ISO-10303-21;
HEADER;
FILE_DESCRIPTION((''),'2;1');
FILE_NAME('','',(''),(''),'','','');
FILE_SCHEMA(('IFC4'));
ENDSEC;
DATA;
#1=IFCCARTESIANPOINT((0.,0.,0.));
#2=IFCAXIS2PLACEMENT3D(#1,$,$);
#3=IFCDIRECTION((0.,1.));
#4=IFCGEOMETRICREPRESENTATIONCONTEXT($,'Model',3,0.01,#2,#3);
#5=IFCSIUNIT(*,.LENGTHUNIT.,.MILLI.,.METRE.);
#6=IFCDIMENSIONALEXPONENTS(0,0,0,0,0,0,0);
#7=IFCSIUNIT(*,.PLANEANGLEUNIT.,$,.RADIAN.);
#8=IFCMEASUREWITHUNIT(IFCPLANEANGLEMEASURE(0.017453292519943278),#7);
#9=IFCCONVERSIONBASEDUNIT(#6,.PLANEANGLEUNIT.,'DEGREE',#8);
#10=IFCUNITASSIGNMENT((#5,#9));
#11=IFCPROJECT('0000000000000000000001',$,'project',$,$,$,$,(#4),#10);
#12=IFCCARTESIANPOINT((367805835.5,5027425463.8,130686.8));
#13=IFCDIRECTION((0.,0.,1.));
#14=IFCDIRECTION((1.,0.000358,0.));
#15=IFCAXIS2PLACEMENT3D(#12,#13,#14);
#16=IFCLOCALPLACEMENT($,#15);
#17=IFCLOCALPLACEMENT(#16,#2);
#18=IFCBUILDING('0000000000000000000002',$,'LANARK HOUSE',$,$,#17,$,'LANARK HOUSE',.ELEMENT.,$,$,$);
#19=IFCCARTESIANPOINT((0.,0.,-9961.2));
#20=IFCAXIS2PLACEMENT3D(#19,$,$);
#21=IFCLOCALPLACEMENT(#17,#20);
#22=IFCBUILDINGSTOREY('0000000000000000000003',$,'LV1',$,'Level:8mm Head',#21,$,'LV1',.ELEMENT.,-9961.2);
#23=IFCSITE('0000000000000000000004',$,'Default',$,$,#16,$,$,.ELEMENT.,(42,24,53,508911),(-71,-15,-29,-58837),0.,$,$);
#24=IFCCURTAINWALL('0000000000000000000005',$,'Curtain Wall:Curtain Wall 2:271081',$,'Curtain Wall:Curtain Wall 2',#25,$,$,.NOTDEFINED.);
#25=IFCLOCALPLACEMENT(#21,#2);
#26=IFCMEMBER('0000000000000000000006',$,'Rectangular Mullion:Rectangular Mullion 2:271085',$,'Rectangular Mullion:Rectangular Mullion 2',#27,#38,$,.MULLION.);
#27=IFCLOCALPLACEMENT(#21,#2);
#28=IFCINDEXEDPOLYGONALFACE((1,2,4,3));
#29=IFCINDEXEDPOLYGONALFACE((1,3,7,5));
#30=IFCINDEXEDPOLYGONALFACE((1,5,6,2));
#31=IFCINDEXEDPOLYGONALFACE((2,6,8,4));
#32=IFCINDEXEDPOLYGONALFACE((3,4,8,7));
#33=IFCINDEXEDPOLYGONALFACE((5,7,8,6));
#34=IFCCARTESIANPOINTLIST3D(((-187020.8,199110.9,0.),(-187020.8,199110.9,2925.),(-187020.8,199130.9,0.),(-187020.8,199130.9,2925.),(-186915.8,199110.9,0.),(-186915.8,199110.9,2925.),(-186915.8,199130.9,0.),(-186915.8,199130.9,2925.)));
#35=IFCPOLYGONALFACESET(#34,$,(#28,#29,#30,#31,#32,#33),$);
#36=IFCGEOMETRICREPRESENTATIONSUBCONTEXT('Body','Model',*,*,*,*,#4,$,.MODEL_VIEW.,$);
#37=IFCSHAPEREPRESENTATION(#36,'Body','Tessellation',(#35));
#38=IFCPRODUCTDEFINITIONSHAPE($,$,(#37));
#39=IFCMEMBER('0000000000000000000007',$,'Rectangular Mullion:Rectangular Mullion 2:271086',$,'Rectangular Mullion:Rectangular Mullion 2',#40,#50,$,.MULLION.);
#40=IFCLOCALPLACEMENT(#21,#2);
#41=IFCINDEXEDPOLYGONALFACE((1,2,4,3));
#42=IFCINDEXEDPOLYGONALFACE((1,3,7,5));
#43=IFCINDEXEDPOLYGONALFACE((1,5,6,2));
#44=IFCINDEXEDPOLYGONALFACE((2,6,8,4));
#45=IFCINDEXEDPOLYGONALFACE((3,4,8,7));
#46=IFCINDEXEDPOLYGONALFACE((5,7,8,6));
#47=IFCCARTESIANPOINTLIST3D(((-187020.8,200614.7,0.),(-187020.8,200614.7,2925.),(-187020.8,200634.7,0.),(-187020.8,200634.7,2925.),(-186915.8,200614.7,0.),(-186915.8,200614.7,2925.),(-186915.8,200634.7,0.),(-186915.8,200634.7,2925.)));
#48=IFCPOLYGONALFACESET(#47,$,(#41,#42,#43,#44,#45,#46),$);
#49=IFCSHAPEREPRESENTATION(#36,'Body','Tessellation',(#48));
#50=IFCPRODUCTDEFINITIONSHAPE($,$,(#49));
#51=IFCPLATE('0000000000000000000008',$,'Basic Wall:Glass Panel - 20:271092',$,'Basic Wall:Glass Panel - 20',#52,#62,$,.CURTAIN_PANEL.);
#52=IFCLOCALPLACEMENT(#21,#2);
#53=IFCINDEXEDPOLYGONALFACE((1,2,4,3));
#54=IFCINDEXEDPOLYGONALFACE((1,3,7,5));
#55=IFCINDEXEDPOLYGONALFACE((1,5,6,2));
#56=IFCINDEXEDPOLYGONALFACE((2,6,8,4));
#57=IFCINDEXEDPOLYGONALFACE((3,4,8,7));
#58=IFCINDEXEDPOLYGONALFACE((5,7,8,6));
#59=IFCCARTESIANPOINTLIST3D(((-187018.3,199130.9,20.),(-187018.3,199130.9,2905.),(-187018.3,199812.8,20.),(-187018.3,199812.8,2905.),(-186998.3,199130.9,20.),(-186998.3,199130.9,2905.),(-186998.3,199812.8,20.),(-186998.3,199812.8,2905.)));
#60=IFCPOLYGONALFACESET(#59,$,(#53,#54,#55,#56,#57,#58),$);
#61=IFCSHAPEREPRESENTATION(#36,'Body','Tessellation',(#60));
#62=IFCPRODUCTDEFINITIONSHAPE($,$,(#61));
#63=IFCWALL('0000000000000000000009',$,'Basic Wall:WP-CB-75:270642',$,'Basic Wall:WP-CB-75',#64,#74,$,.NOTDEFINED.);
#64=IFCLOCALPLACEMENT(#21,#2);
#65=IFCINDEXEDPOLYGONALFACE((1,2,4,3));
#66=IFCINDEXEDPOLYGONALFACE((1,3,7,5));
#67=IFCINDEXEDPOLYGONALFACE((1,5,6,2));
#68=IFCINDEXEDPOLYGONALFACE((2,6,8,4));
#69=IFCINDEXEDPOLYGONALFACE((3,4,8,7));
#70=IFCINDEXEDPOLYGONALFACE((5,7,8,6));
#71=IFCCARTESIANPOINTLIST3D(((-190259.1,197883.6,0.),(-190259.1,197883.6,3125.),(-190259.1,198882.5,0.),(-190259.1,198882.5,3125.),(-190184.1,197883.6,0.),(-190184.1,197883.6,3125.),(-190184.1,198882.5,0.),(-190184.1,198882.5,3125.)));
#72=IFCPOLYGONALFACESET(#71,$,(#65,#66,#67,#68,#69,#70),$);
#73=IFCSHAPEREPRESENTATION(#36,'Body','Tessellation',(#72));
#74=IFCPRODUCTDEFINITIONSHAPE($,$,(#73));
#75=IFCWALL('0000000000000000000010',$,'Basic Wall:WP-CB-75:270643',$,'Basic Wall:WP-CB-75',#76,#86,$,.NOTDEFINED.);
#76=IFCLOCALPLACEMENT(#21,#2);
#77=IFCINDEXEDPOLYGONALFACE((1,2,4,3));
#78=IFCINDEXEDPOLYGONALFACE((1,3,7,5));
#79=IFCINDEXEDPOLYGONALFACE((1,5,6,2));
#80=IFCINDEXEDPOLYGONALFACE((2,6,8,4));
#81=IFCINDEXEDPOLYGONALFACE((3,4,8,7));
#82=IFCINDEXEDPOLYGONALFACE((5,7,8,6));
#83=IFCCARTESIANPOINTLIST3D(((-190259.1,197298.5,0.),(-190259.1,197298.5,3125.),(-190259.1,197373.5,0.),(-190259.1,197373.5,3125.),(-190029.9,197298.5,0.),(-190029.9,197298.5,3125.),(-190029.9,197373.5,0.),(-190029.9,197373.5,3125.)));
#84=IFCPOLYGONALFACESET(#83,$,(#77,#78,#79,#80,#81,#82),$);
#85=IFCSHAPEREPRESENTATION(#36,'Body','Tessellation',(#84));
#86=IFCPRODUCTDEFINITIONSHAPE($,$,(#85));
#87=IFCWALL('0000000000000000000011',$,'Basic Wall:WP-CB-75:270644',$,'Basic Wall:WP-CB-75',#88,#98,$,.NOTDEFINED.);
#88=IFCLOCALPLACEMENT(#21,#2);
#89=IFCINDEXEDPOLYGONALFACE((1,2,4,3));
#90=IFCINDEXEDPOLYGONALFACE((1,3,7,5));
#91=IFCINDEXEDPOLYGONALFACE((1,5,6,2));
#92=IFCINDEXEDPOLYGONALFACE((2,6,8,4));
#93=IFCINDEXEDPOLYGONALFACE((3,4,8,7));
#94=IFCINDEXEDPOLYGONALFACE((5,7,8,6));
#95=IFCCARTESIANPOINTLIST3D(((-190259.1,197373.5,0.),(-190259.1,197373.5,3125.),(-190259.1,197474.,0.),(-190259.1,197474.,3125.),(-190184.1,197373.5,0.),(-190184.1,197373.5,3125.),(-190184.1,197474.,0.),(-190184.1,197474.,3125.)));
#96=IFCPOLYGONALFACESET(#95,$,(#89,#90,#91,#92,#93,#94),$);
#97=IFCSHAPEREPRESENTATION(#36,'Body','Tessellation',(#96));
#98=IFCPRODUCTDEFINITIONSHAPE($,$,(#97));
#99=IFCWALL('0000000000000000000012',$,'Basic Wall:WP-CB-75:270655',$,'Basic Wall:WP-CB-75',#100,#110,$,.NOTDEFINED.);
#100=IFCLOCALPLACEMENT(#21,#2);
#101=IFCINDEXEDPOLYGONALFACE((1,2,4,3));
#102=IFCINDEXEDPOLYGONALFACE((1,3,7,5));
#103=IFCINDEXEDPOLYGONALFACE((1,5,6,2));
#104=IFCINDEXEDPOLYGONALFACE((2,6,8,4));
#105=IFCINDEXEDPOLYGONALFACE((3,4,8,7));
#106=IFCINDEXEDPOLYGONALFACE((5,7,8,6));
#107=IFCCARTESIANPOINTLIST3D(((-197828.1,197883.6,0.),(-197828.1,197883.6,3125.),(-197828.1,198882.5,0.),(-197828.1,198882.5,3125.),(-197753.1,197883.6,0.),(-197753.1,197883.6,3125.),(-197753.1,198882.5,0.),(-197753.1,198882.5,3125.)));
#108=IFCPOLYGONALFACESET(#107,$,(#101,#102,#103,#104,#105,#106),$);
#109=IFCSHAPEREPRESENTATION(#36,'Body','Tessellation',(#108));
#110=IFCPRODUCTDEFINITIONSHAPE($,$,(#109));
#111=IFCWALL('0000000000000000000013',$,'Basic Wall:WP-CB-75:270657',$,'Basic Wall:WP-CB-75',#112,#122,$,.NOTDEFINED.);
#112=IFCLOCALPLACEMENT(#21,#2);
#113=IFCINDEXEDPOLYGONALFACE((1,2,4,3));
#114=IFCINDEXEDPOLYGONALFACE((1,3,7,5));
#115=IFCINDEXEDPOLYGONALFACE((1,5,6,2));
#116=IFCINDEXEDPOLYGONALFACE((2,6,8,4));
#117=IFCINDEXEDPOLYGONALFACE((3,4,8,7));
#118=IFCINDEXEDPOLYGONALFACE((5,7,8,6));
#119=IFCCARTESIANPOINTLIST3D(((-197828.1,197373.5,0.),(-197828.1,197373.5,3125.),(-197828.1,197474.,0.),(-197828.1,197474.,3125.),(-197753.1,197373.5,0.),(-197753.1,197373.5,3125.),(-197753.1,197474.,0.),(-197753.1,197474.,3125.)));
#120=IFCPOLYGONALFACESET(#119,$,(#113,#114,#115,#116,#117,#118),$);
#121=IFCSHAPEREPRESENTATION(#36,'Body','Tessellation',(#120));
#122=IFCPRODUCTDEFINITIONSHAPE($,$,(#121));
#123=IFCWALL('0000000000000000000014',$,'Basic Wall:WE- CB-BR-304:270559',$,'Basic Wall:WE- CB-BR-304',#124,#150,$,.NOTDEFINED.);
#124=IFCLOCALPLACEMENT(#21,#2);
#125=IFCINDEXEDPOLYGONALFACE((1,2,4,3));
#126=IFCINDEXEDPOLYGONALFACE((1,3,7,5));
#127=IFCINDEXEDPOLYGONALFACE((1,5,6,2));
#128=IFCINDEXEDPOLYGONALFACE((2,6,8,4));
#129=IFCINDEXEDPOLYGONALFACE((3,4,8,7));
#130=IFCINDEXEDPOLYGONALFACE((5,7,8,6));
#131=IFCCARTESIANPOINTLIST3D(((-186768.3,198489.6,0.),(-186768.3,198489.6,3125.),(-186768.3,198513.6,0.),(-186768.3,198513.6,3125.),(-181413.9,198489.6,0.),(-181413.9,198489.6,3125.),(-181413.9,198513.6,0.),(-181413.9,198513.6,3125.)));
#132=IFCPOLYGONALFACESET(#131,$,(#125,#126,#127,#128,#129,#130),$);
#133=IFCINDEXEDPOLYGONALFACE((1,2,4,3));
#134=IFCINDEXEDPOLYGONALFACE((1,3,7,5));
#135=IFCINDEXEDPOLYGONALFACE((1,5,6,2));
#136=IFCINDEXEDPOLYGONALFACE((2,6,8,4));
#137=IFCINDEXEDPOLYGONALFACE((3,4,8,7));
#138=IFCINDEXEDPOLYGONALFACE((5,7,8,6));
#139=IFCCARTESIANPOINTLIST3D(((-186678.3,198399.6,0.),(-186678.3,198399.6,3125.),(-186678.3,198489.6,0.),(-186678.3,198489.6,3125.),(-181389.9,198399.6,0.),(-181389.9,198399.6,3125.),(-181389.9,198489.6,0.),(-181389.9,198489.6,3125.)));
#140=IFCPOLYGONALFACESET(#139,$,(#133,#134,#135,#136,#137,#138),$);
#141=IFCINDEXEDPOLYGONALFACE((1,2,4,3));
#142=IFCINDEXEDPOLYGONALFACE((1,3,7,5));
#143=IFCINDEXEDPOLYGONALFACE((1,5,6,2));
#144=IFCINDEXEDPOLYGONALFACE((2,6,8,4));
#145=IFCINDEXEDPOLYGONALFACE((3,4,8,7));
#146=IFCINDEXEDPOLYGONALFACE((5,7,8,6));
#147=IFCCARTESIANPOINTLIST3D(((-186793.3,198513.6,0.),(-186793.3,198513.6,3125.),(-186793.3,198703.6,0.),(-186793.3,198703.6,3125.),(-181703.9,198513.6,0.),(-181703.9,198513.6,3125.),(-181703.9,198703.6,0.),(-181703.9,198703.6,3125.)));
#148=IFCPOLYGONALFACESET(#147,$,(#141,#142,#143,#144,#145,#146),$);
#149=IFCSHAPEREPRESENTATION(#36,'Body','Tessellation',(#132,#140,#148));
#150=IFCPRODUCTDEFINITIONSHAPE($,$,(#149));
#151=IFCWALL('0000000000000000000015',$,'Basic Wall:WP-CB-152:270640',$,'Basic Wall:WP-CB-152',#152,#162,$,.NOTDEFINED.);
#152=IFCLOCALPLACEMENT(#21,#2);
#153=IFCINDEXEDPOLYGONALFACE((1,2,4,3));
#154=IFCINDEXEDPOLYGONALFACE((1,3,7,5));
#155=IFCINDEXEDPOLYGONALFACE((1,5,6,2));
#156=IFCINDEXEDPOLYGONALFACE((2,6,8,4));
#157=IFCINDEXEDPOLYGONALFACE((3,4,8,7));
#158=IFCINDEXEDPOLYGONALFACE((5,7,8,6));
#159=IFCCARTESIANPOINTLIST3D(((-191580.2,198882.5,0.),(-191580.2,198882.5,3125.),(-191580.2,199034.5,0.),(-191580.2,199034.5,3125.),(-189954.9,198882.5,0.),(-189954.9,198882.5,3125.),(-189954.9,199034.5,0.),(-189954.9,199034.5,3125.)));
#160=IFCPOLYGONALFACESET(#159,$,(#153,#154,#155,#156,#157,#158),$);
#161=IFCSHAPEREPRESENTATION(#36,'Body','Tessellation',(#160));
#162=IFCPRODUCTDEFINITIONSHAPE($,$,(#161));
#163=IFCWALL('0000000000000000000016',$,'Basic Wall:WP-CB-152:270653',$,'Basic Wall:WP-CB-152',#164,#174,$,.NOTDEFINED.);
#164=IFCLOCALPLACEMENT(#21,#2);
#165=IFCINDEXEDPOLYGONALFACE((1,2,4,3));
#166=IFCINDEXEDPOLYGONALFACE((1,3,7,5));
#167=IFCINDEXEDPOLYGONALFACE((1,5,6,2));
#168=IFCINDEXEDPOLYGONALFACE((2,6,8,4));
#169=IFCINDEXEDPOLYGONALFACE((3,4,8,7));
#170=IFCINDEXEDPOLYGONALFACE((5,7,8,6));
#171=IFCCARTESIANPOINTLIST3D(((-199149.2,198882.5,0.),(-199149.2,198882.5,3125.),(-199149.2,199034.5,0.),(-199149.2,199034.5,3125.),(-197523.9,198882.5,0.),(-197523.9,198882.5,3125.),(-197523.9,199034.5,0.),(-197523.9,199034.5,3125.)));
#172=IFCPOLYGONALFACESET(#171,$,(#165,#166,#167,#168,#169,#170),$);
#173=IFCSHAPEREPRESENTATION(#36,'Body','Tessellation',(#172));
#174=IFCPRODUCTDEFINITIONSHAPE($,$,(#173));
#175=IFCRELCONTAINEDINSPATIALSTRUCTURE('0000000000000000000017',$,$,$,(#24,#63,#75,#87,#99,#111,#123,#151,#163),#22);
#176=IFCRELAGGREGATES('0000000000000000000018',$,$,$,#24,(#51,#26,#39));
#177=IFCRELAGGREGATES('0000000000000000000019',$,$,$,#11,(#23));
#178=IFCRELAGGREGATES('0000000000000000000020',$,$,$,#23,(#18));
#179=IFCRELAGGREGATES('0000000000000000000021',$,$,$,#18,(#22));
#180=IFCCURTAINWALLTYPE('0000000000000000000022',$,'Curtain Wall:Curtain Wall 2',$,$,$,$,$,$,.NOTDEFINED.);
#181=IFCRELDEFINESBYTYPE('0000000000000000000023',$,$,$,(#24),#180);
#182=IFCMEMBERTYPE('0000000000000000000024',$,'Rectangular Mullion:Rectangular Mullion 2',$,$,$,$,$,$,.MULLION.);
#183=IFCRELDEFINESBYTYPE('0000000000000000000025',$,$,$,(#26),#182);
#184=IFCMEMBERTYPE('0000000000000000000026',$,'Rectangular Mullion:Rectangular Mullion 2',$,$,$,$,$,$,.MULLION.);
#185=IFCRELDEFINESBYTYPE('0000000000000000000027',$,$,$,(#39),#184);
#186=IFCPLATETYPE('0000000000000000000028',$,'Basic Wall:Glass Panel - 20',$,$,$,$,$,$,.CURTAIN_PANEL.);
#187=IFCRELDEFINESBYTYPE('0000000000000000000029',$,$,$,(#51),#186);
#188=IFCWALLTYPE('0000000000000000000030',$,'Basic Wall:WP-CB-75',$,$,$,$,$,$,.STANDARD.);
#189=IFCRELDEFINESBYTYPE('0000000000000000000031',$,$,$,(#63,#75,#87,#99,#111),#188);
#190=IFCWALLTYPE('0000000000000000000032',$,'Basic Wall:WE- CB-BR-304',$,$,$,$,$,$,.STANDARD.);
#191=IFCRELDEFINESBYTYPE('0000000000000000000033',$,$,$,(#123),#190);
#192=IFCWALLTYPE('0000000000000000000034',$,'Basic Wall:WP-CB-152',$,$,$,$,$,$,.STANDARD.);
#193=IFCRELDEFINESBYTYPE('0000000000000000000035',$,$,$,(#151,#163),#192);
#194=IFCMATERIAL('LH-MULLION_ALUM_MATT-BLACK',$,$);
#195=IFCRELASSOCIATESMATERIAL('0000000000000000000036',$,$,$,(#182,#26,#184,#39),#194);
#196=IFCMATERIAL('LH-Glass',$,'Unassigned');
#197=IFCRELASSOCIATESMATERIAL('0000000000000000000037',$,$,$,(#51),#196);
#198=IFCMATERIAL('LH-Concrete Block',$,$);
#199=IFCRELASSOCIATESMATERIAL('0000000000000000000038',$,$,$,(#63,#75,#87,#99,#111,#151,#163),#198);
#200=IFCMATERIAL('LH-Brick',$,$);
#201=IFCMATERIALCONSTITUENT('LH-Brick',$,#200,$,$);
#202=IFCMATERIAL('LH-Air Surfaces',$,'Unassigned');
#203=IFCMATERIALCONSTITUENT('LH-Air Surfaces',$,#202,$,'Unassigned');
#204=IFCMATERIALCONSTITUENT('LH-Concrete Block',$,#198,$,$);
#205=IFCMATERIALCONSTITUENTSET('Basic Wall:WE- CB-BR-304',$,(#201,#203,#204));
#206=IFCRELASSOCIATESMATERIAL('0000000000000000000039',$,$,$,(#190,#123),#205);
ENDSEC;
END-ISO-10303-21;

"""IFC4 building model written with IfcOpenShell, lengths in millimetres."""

from ifc_helpers import new_model, entity, si_unit, converted_unit, direction, frame, origin, place, context, subcontext, project, spatial, indexed_curve, outline, extrude, source, transform, mapped, material, constituent, constituent_set, type_object, type_shapes, element, aggregate, save


model = new_model("IFC4")

# Units and contexts
model_context = context("Model", 3, precision=0.01, world=origin(), true_north=direction((0.0, 1.0)))
body_context = subcontext(model_context, "Body", "Model", "MODEL_VIEW")
ifc_project = project(units=[si_unit("LENGTHUNIT", "METRE", prefix="MILLI"), converted_unit("PLANEANGLEUNIT", "DEGREE", entity("IfcPlaneAngleMeasure", 0.017453292519943278), si_unit("PLANEANGLEUNIT", "RADIAN"), dimensions=[0, 0, 0, 0, 0, 0, 0])], contexts=[model_context])

# Site, building, storey
site_placement = place(None, frame((367805835.5, 5027425463.8, 130686.8), z_axis=(0.0, 0.0, 1.0), x_axis=(1.0, 0.000358, 0.0)))
site = spatial("IfcSite", under=ifc_project, at=site_placement, Name="Default", CompositionType="ELEMENT", RefLatitude=(42, 24, 53, 508911), RefLongitude=(-71, -15, -29, -58837), RefElevation=0.0)
building_placement = place(site_placement, origin())
building = spatial("IfcBuilding", under=site, at=building_placement, Name="LANARK HOUSE", LongName="LANARK HOUSE", CompositionType="ELEMENT")
storey_placement = place(building_placement, frame((0.0, 0.0, -9961.2)))
storey = spatial("IfcBuildingStorey", under=building, at=storey_placement, Name="LV1", ObjectType="Level:8mm Head", LongName="LV1", CompositionType="ELEMENT", Elevation=-9961.2)

# Curtain wall, members
curtain_wall_type = type_object("IfcCurtainWallType", Name="Curtain Wall:Curtain Wall 2", PredefinedType="NOTDEFINED")
curtain_wall_placement = place(storey_placement, frame((0.0, 0.0, 9961.2)))
curtain_wall = element("IfcCurtainWall", 1, at=curtain_wall_placement, inside=storey, type_object=curtain_wall_type, Name="Curtain Wall:Curtain Wall 2:271081", ObjectType="Curtain Wall:Curtain Wall 2", PredefinedType="NOTDEFINED")
ifc_material_1 = material(Name="LH-MULLION_ALUM_MATT-BLACK")
member_type_1 = type_object("IfcMemberType", Name="Rectangular Mullion:Rectangular Mullion 2", PredefinedType="MULLION", material=ifc_material_1)
shared_shape_1 = source(origin(), body_context, "Body", "SweptSolid", [
    extrude(outline(indexed_curve([(-10.0, -52.5), (10.0, -52.5), (10.0, 52.5), (-10.0, 52.5), (-10.0, -52.5)], self_intersect=False)), frame((-10.0, -40.0, -2925.0), z_axis=(0.0, 0.0, 1.0), x_axis=(-1.0, 0.0, 0.0)), (0.0, 0.0, 1.0), 2925.0),
])
type_shapes(member_type_1, [shared_shape_1])
member_1_placement = place(curtain_wall_placement, frame((-187008.3, 199110.9, -9961.2), z_axis=(0.0, 0.0, -1.0), x_axis=(0.0, -1.0, 0.0)))
member_1 = element("IfcMember", 2, at=member_1_placement, type_object=member_type_1, material=ifc_material_1, Name="Rectangular Mullion:Rectangular Mullion 2:271085", ObjectType="Rectangular Mullion:Rectangular Mullion 2", PredefinedType="MULLION", context=body_context, shape_type="MappedRepresentation", body=[
    mapped(shared_shape_1, transform((0.0, 0.0, 0.0), scale=1.0)),
])
member_type_2 = type_object("IfcMemberType", Name="Rectangular Mullion:Rectangular Mullion 2", PredefinedType="MULLION", material=ifc_material_1)
shared_shape_2 = source(origin(), body_context, "Body", "SweptSolid", [
    extrude(outline(indexed_curve([(-10.0, -52.5), (10.0, -52.5), (10.0, 52.5), (-10.0, 52.5), (-10.0, -52.5)], self_intersect=False)), frame((-10.0, -40.0, -2925.0), z_axis=(0.0, 0.0, 1.0), x_axis=(-1.0, 0.0, 0.0)), (0.0, 0.0, 1.0), 2925.0),
])
type_shapes(member_type_2, [shared_shape_2])
member_2_placement = place(curtain_wall_placement, frame((-187008.3, 200634.7, -7036.2), z_axis=(0.0, 0.0, 1.0), x_axis=(0.0, 1.0, 0.0)))
member_2 = element("IfcMember", 3, at=member_2_placement, type_object=member_type_2, material=ifc_material_1, Name="Rectangular Mullion:Rectangular Mullion 2:271086", ObjectType="Rectangular Mullion:Rectangular Mullion 2", PredefinedType="MULLION", context=body_context, shape_type="MappedRepresentation", body=[
    mapped(shared_shape_2, transform((0.0, 0.0, 0.0), scale=1.0)),
])

# Plate
ifc_material_2 = material(Name="LH-Glass", Category="Unassigned")
plate_type = type_object("IfcPlateType", Name="Basic Wall:Glass Panel - 20", PredefinedType="CURTAIN_PANEL")
plate_placement = place(storey_placement, frame((-187008.3, 199812.8, 20.0), z_axis=(0.0, 0.0, 1.0), x_axis=(0.0, -1.0, 0.0)))
plate = element("IfcPlate", 4, at=plate_placement, type_object=plate_type, material=ifc_material_2, Name="Basic Wall:Glass Panel - 20:271092", ObjectType="Basic Wall:Glass Panel - 20", PredefinedType="CURTAIN_PANEL", context=body_context, shape_type="SweptSolid", body=[
    extrude(outline(indexed_curve([(-10.0, -341.0), (10.0, -341.0), (10.0, 341.0), (-10.0, 341.0), (-10.0, -341.0)], self_intersect=False)), frame((341.0, 0.0, 0.0), z_axis=(0.0, 0.0, 1.0), x_axis=(0.0, 1.0, 0.0)), (0.0, 0.0, 1.0), 2885.0),
])

# Walls
ifc_material_3 = material(Name="LH-Brick")
ifc_material_4 = material(Name="LH-Air Surfaces", Category="Unassigned")
ifc_material_5 = material(Name="LH-Concrete Block")
wall_type_1 = type_object("IfcWallType", Name="Basic Wall:WP-CB-75", PredefinedType="STANDARD")
wall_1_placement = place(storey_placement, frame((-190221.6, 198882.5, 0.0), z_axis=(0.0, 0.0, 1.0), x_axis=(0.0, -1.0, 0.0)))
element("IfcWall", 5, at=wall_1_placement, inside=storey, type_object=wall_type_1, material=ifc_material_5, Name="Basic Wall:WP-CB-75:270642", ObjectType="Basic Wall:WP-CB-75", PredefinedType="NOTDEFINED", context=body_context, shape_type="SweptSolid", body=[
    extrude(outline(indexed_curve([(998.9, 37.5), (0.0, 37.5), (0.0, -37.5), (998.9, -37.5), (998.9, 37.5)], self_intersect=False)), origin(), (0.0, 0.0, 1.0), 3125.0),
])
wall_2_placement = place(storey_placement, frame((-190029.9, 197336.0, 0.0), z_axis=(0.0, 0.0, 1.0), x_axis=(-1.0, 0.0, 0.0)))
element("IfcWall", 6, at=wall_2_placement, inside=storey, type_object=wall_type_1, material=ifc_material_5, Name="Basic Wall:WP-CB-75:270643", ObjectType="Basic Wall:WP-CB-75", PredefinedType="NOTDEFINED", context=body_context, shape_type="SweptSolid", body=[
    extrude(outline(indexed_curve([(229.2, 37.5), (0.0, 37.5), (0.0, -37.5), (229.2, -37.5), (229.2, 37.5)], self_intersect=False)), origin(), (0.0, 0.0, 1.0), 3125.0),
])
wall_3_placement = place(storey_placement, frame((-190221.6, 197373.5, 0.0), z_axis=(0.0, 0.0, 1.0), x_axis=(0.0, 1.0, 0.0)))
element("IfcWall", 7, at=wall_3_placement, inside=storey, type_object=wall_type_1, material=ifc_material_5, Name="Basic Wall:WP-CB-75:270644", ObjectType="Basic Wall:WP-CB-75", PredefinedType="NOTDEFINED", context=body_context, shape_type="SweptSolid", body=[
    extrude(outline(indexed_curve([(100.5, 37.5), (0.0, 37.5), (0.0, -37.5), (100.5, -37.5), (100.5, 37.5)], self_intersect=False)), origin(), (0.0, 0.0, 1.0), 3125.0),
])
wall_4_placement = place(storey_placement, frame((-197790.6, 198882.5, 0.0), z_axis=(0.0, 0.0, 1.0), x_axis=(0.0, -1.0, 0.0)))
element("IfcWall", 8, at=wall_4_placement, inside=storey, type_object=wall_type_1, material=ifc_material_5, Name="Basic Wall:WP-CB-75:270655", ObjectType="Basic Wall:WP-CB-75", PredefinedType="NOTDEFINED", context=body_context, shape_type="SweptSolid", body=[
    extrude(outline(indexed_curve([(998.9, 37.5), (0.0, 37.5), (0.0, -37.5), (998.9, -37.5), (998.9, 37.5)], self_intersect=False)), origin(), (0.0, 0.0, 1.0), 3125.0),
])
wall_5_placement = place(storey_placement, frame((-197790.6, 197373.5, 0.0), z_axis=(0.0, 0.0, 1.0), x_axis=(0.0, 1.0, 0.0)))
element("IfcWall", 9, at=wall_5_placement, inside=storey, type_object=wall_type_1, material=ifc_material_5, Name="Basic Wall:WP-CB-75:270657", ObjectType="Basic Wall:WP-CB-75", PredefinedType="NOTDEFINED", context=body_context, shape_type="SweptSolid", body=[
    extrude(outline(indexed_curve([(100.5, 37.5), (0.0, 37.5), (0.0, -37.5), (100.5, -37.5), (100.5, 37.5)], self_intersect=False)), origin(), (0.0, 0.0, 1.0), 3125.0),
])
ifc_constituent_1 = constituent(ifc_material_3, Name="LH-Brick")
ifc_constituent_2 = constituent(ifc_material_4, Name="LH-Air Surfaces", Category="Unassigned")
ifc_constituent_3 = constituent(ifc_material_5, Name="LH-Concrete Block")
ifc_constituent_set_1 = constituent_set(constituents=[ifc_constituent_1, ifc_constituent_2, ifc_constituent_3], Name="Basic Wall:WE- CB-BR-304")
wall_type_2 = type_object("IfcWallType", Name="Basic Wall:WE- CB-BR-304", PredefinedType="STANDARD", material=ifc_constituent_set_1)
wall_6_placement = place(storey_placement, frame((-181703.9, 198551.6, 0.0), z_axis=(0.0, 0.0, 1.0), x_axis=(-1.0, 0.0, 0.0)))
element("IfcWall", 10, at=wall_6_placement, inside=storey, type_object=wall_type_2, material=ifc_constituent_set_1, Name="Basic Wall:WE- CB-BR-304:270559", ObjectType="Basic Wall:WE- CB-BR-304", PredefinedType="NOTDEFINED", context=body_context, shape_type="SweptSolid", body=[
    extrude(outline(indexed_curve([(-2677.2, -12.0), (2677.2, -12.0), (2677.2, 12.0), (-2677.2, 12.0), (-2677.2, -12.0)], self_intersect=False)), frame((2387.2, 50.0, 0.0)), (0.0, 0.0, 1.0), 3125.0),
    extrude(outline(indexed_curve([(-45.0, -2644.2), (45.0, -2644.2), (45.0, 2644.2), (-45.0, 2644.2), (-45.0, -2644.2)], self_intersect=False)), frame((2330.2, 107.0, 0.0), z_axis=(0.0, 0.0, 1.0), x_axis=(0.0, -1.0, 0.0)), (0.0, 0.0, 1.0), 3125.0),
    extrude(outline(indexed_curve([(-95.0, -2544.7), (95.0, -2544.7), (95.0, 2544.7), (-95.0, 2544.7), (-95.0, -2544.7)], self_intersect=False)), frame((2544.7, -57.0, 0.0), z_axis=(0.0, 0.0, 1.0), x_axis=(0.0, 1.0, 0.0)), (0.0, 0.0, 1.0), 3125.0),
])
wall_type_3 = type_object("IfcWallType", Name="Basic Wall:WP-CB-152", PredefinedType="STANDARD")
for number, where, name in (
    (11, (-191580.2, 198958.5, 0.0), "Basic Wall:WP-CB-152:270640"),
    (12, (-199149.2, 198958.5, 0.0), "Basic Wall:WP-CB-152:270653"),
):
    element("IfcWall", number, at=place(storey_placement, frame(where)), inside=storey, type_object=wall_type_3, material=ifc_material_5, Name=name, ObjectType="Basic Wall:WP-CB-152", PredefinedType="NOTDEFINED", context=body_context, shape_type="SweptSolid", body=[
        extrude(outline(indexed_curve([(1625.3, 76.0), (0.0, 76.0), (0.0, -76.0), (1625.3, -76.0), (1625.3, 76.0)], self_intersect=False)), origin(), (0.0, 0.0, 1.0), 3125.0),
    ])

aggregate(curtain_wall, [plate, member_1, member_2])

save(model, "model.ifc")
